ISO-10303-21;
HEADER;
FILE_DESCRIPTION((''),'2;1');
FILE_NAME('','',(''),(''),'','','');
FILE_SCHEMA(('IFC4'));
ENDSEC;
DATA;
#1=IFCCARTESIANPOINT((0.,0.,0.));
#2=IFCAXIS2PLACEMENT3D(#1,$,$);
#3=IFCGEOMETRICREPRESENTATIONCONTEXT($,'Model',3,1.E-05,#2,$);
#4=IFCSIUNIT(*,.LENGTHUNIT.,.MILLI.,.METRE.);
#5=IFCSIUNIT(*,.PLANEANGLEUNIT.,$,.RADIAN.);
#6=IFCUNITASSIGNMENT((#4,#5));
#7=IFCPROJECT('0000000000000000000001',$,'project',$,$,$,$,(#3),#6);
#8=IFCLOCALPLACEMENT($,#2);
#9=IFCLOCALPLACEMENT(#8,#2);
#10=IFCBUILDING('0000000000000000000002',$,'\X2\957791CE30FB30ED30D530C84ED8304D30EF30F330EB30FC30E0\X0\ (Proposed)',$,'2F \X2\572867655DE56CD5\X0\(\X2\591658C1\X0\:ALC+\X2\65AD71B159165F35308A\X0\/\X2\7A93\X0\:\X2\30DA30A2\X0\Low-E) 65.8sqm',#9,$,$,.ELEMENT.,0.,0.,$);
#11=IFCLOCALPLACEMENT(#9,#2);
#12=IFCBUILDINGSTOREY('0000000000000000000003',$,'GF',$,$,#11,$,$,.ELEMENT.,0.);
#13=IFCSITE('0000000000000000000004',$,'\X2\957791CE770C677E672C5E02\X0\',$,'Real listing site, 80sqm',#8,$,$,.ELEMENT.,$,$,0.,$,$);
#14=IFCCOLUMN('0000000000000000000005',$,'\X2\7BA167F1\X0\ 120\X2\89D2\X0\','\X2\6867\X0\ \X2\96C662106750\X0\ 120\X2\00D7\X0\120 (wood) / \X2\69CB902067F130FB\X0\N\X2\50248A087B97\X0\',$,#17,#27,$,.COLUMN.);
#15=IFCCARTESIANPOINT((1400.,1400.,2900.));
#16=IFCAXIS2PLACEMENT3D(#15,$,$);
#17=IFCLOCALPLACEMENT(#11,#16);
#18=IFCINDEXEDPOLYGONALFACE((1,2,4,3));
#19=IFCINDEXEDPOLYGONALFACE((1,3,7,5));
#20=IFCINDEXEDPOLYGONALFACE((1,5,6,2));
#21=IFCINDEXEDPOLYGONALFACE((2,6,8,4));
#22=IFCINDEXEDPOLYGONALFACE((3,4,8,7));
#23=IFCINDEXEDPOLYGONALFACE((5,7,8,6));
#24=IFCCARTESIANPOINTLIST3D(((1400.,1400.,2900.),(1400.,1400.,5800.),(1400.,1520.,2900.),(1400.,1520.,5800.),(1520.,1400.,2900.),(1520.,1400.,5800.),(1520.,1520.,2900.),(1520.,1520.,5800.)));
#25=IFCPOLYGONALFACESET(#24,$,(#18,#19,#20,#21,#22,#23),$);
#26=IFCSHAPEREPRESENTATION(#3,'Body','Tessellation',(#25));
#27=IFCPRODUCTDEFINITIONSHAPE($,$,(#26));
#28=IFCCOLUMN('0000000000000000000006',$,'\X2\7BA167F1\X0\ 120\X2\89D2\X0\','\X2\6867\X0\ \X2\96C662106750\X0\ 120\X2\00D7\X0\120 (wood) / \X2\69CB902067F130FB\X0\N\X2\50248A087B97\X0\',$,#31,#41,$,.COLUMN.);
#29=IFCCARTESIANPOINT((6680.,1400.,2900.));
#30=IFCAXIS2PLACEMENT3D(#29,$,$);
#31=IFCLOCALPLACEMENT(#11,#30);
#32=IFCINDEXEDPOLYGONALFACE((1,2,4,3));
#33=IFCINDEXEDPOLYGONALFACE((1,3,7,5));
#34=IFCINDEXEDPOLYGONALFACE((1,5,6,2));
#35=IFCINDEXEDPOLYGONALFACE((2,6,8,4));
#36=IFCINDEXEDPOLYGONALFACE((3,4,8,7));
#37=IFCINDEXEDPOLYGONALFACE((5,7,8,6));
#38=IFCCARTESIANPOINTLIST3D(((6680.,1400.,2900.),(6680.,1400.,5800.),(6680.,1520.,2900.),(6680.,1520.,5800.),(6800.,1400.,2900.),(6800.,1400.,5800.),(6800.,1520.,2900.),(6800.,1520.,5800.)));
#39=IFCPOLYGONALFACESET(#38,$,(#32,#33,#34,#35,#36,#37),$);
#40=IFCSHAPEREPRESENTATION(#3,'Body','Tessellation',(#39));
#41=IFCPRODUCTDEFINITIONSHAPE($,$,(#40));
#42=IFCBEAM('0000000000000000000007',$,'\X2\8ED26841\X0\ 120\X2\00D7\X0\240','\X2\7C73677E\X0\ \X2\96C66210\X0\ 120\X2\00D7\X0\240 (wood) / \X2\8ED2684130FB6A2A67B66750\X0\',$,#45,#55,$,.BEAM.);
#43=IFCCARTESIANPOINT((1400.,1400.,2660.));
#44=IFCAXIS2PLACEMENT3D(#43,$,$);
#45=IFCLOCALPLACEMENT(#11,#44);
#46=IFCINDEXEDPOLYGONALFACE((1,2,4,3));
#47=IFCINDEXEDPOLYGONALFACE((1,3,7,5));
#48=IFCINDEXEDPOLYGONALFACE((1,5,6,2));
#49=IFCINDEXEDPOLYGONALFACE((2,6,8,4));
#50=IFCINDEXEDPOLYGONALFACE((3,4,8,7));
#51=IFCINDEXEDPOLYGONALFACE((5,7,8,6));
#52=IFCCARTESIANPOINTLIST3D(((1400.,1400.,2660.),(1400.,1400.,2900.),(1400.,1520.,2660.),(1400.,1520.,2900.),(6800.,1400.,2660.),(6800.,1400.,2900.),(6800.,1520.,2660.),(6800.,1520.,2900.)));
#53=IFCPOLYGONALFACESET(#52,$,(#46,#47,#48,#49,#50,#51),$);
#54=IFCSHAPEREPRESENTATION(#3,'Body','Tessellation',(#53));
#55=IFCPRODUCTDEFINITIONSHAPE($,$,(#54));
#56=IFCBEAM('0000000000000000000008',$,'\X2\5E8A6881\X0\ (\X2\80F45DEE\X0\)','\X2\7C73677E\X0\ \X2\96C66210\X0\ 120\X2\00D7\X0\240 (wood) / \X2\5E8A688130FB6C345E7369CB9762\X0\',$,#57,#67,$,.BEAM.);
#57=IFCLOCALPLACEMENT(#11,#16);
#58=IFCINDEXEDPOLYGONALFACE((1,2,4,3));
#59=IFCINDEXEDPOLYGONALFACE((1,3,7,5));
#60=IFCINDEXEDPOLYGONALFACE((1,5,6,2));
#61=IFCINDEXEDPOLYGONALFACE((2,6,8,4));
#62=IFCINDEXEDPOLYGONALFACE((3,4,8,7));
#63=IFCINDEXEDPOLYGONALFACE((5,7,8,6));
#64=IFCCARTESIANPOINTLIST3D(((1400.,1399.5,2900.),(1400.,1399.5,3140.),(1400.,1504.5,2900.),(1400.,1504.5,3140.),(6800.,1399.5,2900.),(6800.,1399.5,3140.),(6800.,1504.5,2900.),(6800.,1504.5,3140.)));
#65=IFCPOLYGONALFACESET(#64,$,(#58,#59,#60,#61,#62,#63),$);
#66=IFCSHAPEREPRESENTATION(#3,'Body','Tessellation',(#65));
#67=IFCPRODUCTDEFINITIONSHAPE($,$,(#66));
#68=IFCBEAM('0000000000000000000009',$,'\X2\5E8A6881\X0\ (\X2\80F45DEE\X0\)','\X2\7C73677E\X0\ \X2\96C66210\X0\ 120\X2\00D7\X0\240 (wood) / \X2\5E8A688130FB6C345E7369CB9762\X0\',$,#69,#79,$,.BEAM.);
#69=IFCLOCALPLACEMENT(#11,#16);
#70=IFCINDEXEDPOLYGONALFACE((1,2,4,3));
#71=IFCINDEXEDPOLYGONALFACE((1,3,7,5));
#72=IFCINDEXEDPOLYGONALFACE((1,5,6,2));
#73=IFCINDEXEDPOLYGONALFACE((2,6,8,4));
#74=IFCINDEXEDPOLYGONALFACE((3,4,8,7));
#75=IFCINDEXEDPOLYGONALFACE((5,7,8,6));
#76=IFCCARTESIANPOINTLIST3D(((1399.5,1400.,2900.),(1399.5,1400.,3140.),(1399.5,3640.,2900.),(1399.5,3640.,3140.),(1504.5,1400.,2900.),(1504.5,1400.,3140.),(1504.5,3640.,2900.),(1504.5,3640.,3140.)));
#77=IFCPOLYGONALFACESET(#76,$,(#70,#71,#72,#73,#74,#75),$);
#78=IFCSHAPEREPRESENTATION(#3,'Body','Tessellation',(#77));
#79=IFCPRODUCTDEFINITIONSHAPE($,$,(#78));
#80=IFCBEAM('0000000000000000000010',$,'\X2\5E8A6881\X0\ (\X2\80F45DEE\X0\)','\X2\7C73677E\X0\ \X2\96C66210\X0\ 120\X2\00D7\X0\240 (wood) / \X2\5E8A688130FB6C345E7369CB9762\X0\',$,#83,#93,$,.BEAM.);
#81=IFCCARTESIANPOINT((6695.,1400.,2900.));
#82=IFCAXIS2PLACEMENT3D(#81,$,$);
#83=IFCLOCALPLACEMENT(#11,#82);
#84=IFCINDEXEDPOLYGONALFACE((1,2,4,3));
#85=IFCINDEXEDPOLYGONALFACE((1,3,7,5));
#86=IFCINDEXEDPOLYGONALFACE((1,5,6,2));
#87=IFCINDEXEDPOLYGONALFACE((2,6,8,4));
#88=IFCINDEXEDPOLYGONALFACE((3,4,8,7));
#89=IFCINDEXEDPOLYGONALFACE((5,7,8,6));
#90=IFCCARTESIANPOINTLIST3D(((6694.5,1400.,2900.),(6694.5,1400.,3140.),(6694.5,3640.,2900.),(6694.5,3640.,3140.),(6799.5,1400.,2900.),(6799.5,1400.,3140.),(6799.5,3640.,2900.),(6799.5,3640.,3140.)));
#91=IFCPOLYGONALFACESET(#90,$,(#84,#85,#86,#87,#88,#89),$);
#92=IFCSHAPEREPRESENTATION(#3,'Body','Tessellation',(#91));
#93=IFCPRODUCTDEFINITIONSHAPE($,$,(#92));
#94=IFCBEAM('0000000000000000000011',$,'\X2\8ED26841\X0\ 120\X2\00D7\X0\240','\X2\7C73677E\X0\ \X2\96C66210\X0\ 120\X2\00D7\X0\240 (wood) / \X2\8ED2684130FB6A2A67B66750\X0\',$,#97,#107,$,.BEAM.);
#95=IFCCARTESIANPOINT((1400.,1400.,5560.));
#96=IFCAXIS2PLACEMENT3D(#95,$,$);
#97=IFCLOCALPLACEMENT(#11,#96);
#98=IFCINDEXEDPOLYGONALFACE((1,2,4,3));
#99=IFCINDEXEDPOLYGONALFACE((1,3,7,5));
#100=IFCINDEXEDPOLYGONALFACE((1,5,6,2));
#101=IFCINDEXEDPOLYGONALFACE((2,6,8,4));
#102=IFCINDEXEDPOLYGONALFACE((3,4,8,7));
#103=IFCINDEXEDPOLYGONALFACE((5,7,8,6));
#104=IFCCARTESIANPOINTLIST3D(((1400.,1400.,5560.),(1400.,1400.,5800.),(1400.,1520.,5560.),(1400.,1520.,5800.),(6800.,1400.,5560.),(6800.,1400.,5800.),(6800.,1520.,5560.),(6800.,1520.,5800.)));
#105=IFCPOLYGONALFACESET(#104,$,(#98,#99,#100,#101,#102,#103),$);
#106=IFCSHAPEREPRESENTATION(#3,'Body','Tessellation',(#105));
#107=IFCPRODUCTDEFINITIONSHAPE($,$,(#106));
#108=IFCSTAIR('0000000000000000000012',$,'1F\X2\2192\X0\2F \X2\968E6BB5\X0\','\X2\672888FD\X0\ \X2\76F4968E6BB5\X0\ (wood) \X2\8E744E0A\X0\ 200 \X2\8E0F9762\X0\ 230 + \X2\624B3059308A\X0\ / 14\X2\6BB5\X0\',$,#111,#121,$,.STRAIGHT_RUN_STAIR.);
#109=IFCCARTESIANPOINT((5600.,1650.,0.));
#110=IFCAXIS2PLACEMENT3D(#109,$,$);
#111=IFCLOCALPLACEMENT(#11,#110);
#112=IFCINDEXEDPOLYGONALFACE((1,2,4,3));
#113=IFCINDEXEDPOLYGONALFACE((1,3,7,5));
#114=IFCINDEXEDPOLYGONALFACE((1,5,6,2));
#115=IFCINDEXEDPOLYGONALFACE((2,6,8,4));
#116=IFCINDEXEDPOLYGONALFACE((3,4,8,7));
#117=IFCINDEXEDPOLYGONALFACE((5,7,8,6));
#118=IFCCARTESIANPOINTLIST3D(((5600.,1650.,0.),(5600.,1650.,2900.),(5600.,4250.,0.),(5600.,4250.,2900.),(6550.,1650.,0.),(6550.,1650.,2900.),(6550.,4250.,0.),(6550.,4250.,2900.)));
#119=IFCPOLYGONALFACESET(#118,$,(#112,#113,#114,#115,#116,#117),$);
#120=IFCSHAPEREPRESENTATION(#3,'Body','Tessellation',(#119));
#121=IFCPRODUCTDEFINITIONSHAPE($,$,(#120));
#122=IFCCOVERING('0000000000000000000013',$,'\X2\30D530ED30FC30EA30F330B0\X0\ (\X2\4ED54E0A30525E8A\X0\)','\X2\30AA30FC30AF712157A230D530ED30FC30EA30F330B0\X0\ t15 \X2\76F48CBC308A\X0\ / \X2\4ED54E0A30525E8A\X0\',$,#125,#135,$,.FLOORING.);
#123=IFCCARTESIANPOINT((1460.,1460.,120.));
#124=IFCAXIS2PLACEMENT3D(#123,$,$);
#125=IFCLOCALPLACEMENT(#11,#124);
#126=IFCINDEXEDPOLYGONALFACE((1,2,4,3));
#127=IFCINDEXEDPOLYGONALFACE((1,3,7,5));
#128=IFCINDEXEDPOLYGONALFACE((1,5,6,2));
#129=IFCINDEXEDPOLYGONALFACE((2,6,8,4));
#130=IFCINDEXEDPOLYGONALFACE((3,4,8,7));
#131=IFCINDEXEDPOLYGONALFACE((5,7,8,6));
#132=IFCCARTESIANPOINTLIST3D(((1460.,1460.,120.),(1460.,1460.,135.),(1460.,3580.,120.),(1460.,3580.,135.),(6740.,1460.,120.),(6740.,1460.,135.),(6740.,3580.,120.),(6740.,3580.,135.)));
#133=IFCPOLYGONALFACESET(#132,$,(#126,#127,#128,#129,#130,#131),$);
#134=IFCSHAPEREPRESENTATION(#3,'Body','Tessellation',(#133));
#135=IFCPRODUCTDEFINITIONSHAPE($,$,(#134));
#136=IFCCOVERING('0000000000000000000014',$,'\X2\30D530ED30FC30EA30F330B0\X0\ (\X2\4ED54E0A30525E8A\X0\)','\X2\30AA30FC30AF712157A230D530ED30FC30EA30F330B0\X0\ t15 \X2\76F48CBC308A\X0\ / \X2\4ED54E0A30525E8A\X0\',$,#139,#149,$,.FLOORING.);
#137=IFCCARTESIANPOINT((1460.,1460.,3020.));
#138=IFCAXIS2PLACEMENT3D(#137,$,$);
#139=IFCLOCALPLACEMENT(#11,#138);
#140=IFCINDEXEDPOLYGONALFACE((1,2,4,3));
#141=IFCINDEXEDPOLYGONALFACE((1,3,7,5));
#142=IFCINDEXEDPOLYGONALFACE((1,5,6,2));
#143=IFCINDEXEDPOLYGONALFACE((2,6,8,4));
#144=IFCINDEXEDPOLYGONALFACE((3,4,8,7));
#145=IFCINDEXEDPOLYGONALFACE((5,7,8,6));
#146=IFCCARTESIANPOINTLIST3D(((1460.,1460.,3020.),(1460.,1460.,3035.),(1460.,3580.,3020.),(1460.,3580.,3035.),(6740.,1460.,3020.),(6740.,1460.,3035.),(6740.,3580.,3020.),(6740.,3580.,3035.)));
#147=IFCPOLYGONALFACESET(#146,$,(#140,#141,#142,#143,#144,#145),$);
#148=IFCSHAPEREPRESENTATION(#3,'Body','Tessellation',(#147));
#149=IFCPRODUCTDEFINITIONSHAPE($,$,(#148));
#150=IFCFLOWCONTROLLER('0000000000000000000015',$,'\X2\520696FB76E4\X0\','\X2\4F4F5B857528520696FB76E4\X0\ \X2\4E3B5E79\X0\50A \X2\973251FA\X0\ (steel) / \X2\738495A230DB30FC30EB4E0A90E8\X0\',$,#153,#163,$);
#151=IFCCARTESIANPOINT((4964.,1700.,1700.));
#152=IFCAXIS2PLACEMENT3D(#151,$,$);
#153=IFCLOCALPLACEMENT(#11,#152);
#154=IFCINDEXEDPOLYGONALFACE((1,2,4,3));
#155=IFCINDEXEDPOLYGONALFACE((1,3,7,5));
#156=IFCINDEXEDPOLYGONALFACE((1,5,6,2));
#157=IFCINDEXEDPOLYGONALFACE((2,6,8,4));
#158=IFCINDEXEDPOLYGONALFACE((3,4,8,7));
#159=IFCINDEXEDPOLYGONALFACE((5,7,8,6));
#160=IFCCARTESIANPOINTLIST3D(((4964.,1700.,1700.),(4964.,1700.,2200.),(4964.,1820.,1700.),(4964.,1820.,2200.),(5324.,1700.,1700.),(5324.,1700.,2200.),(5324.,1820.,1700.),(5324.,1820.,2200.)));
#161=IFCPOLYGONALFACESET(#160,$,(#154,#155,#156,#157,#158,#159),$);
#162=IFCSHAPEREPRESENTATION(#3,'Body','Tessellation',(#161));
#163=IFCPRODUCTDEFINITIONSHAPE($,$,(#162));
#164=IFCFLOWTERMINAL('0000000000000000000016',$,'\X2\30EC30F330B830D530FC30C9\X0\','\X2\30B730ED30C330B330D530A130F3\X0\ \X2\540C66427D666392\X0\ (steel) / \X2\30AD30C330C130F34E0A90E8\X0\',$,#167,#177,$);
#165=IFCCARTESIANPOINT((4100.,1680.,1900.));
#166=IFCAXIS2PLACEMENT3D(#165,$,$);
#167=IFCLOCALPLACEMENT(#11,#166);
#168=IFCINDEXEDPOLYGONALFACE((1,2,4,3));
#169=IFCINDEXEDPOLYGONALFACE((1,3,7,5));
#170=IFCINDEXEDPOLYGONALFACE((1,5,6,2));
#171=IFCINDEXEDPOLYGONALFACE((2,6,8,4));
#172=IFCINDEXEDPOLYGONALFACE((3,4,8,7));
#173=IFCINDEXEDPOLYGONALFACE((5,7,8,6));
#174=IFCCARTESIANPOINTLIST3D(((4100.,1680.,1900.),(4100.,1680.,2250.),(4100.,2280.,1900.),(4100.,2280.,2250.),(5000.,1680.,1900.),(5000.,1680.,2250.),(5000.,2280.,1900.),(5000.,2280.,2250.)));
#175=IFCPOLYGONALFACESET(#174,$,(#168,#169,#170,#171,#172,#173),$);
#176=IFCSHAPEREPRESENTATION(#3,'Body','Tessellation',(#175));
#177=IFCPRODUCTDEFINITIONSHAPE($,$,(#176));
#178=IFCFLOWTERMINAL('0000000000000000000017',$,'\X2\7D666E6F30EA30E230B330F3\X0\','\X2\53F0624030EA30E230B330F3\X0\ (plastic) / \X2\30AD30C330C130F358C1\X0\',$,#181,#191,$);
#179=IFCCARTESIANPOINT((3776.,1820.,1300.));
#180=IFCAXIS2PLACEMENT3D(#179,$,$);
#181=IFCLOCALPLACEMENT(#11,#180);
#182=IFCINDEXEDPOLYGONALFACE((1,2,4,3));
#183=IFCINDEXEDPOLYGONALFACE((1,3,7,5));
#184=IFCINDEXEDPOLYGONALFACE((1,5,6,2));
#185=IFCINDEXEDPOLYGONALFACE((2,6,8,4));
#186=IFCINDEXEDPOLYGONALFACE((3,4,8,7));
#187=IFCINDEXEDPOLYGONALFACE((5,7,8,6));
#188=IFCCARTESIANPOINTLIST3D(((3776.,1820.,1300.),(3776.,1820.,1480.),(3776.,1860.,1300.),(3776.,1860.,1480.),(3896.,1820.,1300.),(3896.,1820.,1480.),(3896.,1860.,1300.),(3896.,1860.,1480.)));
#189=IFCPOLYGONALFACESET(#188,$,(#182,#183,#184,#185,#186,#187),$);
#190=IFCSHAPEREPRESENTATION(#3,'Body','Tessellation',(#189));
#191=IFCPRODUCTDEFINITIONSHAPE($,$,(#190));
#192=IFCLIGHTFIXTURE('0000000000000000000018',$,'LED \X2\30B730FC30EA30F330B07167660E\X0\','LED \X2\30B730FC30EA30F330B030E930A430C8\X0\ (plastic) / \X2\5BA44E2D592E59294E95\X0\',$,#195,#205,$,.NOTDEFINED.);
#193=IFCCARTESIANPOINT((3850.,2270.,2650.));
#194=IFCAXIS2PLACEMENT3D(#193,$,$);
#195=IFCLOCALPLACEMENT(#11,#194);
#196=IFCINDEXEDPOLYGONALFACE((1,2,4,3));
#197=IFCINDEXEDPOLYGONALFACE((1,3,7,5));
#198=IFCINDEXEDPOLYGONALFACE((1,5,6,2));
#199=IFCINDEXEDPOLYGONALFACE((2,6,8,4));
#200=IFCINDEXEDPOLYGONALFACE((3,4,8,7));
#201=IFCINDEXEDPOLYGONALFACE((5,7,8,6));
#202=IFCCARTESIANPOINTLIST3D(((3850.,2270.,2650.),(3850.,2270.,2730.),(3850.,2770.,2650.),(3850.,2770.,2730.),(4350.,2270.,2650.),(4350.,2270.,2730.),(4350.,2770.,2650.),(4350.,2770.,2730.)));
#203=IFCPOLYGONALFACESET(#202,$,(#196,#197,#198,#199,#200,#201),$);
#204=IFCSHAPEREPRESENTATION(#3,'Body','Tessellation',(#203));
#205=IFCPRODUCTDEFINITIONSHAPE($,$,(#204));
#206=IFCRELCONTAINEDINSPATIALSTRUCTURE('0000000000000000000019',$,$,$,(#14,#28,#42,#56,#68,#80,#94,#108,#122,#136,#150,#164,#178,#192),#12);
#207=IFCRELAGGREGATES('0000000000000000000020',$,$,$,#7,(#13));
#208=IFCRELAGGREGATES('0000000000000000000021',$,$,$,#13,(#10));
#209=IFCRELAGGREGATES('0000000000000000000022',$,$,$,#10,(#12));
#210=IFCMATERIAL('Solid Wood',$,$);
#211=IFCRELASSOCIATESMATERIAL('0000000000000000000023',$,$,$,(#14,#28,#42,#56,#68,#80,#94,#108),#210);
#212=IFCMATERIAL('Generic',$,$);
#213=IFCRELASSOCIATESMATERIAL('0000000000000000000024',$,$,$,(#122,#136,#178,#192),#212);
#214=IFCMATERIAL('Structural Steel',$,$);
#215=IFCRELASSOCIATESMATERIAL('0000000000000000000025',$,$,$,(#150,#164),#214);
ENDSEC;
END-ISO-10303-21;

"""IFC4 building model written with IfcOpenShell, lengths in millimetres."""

from ifc_helpers import new_model, si_unit, frame, frame_2d, origin, place, context, project, spatial, rectangle, extrude, material, element, save


model = new_model("IFC4")

# Units and contexts
model_context = context("Model", 3, precision=1e-05, world=origin())
ifc_project = project(units=[si_unit("LENGTHUNIT", "METRE", prefix="MILLI"), si_unit("PLANEANGLEUNIT", "RADIAN")], contexts=[model_context])

# Site, building, storey
site_placement = place(None, origin())
site = spatial("IfcSite", under=ifc_project, at=site_placement, Name="長野県松本市", ObjectType="Real listing site, 80sqm", CompositionType="ELEMENT", RefElevation=0.0)
building_placement = place(site_placement, origin())
building = spatial("IfcBuilding", under=site, at=building_placement, Name="長野・ロフト付きワンルーム (Proposed)", ObjectType="2F 在来工法(外壁:ALC+断熱外張り/窓:ペアLow-E) 65.8sqm", CompositionType="ELEMENT", ElevationOfRefHeight=0.0, ElevationOfTerrain=0.0)
storey_placement = place(building_placement, origin())
storey = spatial("IfcBuildingStorey", under=building, at=storey_placement, Name="GF", CompositionType="ELEMENT", Elevation=0.0)

# Columns
ifc_material_1 = material(Name="Solid Wood")
column_1_placement = place(storey_placement, frame((1400.0, 1400.0, 2900.0)))
element("IfcColumn", 1, at=column_1_placement, inside=storey, material=ifc_material_1, Name="管柱 120角", Description="桧 集成材 120×120 (wood) / 構造柱・N値計算", PredefinedType="COLUMN", context=model_context, shape_type="SweptSolid", body=[
    extrude(rectangle(XDim=120.0, YDim=120.0, at=frame_2d((60.0, 60.0))), frame((1400.0, 1400.0, 2900.0)), (0.0, 0.0, 1.0), 2900.0),
])
column_2_placement = place(storey_placement, frame((6680.0, 1400.0, 2900.0)))
element("IfcColumn", 2, at=column_2_placement, inside=storey, material=ifc_material_1, Name="管柱 120角", Description="桧 集成材 120×120 (wood) / 構造柱・N値計算", PredefinedType="COLUMN", context=model_context, shape_type="SweptSolid", body=[
    extrude(rectangle(XDim=120.0, YDim=120.0, at=frame_2d((60.0, 60.0))), frame((6680.0, 1400.0, 2900.0)), (0.0, 0.0, 1.0), 2900.0),
])

# Beams
beam_1_placement = place(storey_placement, frame((1400.0, 1400.0, 2660.0)))
element("IfcBeam", 3, at=beam_1_placement, inside=storey, material=ifc_material_1, Name="軒桁 120×240", Description="米松 集成 120×240 (wood) / 軒桁・横架材", PredefinedType="BEAM", context=model_context, shape_type="SweptSolid", body=[
    extrude(rectangle(XDim=5400.0, YDim=120.0, at=frame_2d((2700.0, 60.0))), frame((1400.0, 1400.0, 2660.0)), (0.0, 0.0, 1.0), 240.0),
])
beam_2_placement = place(storey_placement, frame((1400.0, 1400.0, 2900.0)))
element("IfcBeam", 4, at=beam_2_placement, inside=storey, material=ifc_material_1, Name="床梁 (胴差)", Description="米松 集成 120×240 (wood) / 床梁・水平構面", PredefinedType="BEAM", context=model_context, shape_type="SweptSolid", body=[
    extrude(rectangle(XDim=5400.0, YDim=105.0, at=frame_2d((2700.0, 52.0))), frame((1400.0, 1400.0, 2900.0)), (0.0, 0.0, 1.0), 240.0),
])
beam_3_placement = place(storey_placement, frame((1400.0, 1400.0, 2900.0)))
element("IfcBeam", 5, at=beam_3_placement, inside=storey, material=ifc_material_1, Name="床梁 (胴差)", Description="米松 集成 120×240 (wood) / 床梁・水平構面", PredefinedType="BEAM", context=model_context, shape_type="SweptSolid", body=[
    extrude(rectangle(XDim=105.0, YDim=2240.0, at=frame_2d((52.0, 1120.0))), frame((1400.0, 1400.0, 2900.0)), (0.0, 0.0, 1.0), 240.0),
])
beam_4_placement = place(storey_placement, frame((6695.0, 1400.0, 2900.0)))
element("IfcBeam", 6, at=beam_4_placement, inside=storey, material=ifc_material_1, Name="床梁 (胴差)", Description="米松 集成 120×240 (wood) / 床梁・水平構面", PredefinedType="BEAM", context=model_context, shape_type="SweptSolid", body=[
    extrude(rectangle(XDim=105.0, YDim=2240.0, at=frame_2d((52.0, 1120.0))), frame((6695.0, 1400.0, 2900.0)), (0.0, 0.0, 1.0), 240.0),
])
beam_5_placement = place(storey_placement, frame((1400.0, 1400.0, 5560.0)))
element("IfcBeam", 7, at=beam_5_placement, inside=storey, material=ifc_material_1, Name="軒桁 120×240", Description="米松 集成 120×240 (wood) / 軒桁・横架材", PredefinedType="BEAM", context=model_context, shape_type="SweptSolid", body=[
    extrude(rectangle(XDim=5400.0, YDim=120.0, at=frame_2d((2700.0, 60.0))), frame((1400.0, 1400.0, 5560.0)), (0.0, 0.0, 1.0), 240.0),
])

# Stair
stair_placement = place(storey_placement, frame((5600.0, 1650.0, 0.0)))
element("IfcStair", 8, at=stair_placement, inside=storey, material=ifc_material_1, Name="1F→2F 階段", Description="木製 直階段 (wood) 蹴上 200 踏面 230 + 手すり / 14段", PredefinedType="STRAIGHT_RUN_STAIR", context=model_context, shape_type="SweptSolid", body=[
    extrude(rectangle(XDim=950.0, YDim=2600.0, at=frame_2d((475.0, 1300.0))), frame((5600.0, 1650.0, 0.0)), (0.0, 0.0, 1.0), 2900.0),
])

# Coverings
ifc_material_2 = material(Name="Generic")
covering_1_placement = place(storey_placement, frame((1460.0, 1460.0, 120.0)))
element("IfcCovering", 9, at=covering_1_placement, inside=storey, material=ifc_material_2, Name="フローリング (仕上げ床)", Description="オーク無垢フローリング t15 直貼り / 仕上げ床", PredefinedType="FLOORING", context=model_context, shape_type="SweptSolid", body=[
    extrude(rectangle(XDim=5280.0, YDim=2120.0, at=frame_2d((2640.0, 1060.0))), frame((1460.0, 1460.0, 120.0)), (0.0, 0.0, 1.0), 15.0),
])
covering_2_placement = place(storey_placement, frame((1460.0, 1460.0, 3020.0)))
element("IfcCovering", 10, at=covering_2_placement, inside=storey, material=ifc_material_2, Name="フローリング (仕上げ床)", Description="オーク無垢フローリング t15 直貼り / 仕上げ床", PredefinedType="FLOORING", context=model_context, shape_type="SweptSolid", body=[
    extrude(rectangle(XDim=5280.0, YDim=2120.0, at=frame_2d((2640.0, 1060.0))), frame((1460.0, 1460.0, 3020.0)), (0.0, 0.0, 1.0), 15.0),
])

# Flow controller
ifc_material_3 = material(Name="Structural Steel")
flow_controller_placement = place(storey_placement, frame((4964.0, 1700.0, 1700.0)))
element("IfcFlowController", 11, at=flow_controller_placement, inside=storey, material=ifc_material_3, Name="分電盤", Description="住宅用分電盤 主幹50A 露出 (steel) / 玄関ホール上部", context=model_context, shape_type="SweptSolid", body=[
    extrude(rectangle(XDim=360.0, YDim=120.0, at=frame_2d((180.0, 60.0))), frame((4964.0, 1700.0, 1700.0)), (0.0, 0.0, 1.0), 500.0),
])

# Flow terminals
flow_terminal_1_placement = place(storey_placement, frame((4100.0, 1680.0, 1900.0)))
element("IfcFlowTerminal", 12, at=flow_terminal_1_placement, inside=storey, material=ifc_material_3, Name="レンジフード", Description="シロッコファン 同時給排 (steel) / キッチン上部", context=model_context, shape_type="SweptSolid", body=[
    extrude(rectangle(XDim=900.0, YDim=600.0, at=frame_2d((450.0, 300.0))), frame((4100.0, 1680.0, 1900.0)), (0.0, 0.0, 1.0), 350.0),
])
flow_terminal_2_placement = place(storey_placement, frame((3776.0, 1820.0, 1300.0)))
element("IfcFlowTerminal", 13, at=flow_terminal_2_placement, inside=storey, material=ifc_material_2, Name="給湯リモコン", Description="台所リモコン (plastic) / キッチン壁", context=model_context, shape_type="SweptSolid", body=[
    extrude(rectangle(XDim=120.0, YDim=40.0, at=frame_2d((60.0, 20.0))), frame((3776.0, 1820.0, 1300.0)), (0.0, 0.0, 1.0), 180.0),
])

# Light fixture
light_fixture_1_placement = place(storey_placement, frame((3850.0, 2270.0, 2650.0)))
element("IfcLightFixture", 14, at=light_fixture_1_placement, inside=storey, material=ifc_material_2, Name="LED シーリング照明", Description="LED シーリングライト (plastic) / 室中央天井", PredefinedType="NOTDEFINED", context=model_context, shape_type="SweptSolid", body=[
    extrude(rectangle(XDim=500.0, YDim=500.0, at=frame_2d((250.0, 250.0))), frame((3850.0, 2270.0, 2650.0)), (0.0, 0.0, 1.0), 80.0),
])

save(model, "model.ifc")
